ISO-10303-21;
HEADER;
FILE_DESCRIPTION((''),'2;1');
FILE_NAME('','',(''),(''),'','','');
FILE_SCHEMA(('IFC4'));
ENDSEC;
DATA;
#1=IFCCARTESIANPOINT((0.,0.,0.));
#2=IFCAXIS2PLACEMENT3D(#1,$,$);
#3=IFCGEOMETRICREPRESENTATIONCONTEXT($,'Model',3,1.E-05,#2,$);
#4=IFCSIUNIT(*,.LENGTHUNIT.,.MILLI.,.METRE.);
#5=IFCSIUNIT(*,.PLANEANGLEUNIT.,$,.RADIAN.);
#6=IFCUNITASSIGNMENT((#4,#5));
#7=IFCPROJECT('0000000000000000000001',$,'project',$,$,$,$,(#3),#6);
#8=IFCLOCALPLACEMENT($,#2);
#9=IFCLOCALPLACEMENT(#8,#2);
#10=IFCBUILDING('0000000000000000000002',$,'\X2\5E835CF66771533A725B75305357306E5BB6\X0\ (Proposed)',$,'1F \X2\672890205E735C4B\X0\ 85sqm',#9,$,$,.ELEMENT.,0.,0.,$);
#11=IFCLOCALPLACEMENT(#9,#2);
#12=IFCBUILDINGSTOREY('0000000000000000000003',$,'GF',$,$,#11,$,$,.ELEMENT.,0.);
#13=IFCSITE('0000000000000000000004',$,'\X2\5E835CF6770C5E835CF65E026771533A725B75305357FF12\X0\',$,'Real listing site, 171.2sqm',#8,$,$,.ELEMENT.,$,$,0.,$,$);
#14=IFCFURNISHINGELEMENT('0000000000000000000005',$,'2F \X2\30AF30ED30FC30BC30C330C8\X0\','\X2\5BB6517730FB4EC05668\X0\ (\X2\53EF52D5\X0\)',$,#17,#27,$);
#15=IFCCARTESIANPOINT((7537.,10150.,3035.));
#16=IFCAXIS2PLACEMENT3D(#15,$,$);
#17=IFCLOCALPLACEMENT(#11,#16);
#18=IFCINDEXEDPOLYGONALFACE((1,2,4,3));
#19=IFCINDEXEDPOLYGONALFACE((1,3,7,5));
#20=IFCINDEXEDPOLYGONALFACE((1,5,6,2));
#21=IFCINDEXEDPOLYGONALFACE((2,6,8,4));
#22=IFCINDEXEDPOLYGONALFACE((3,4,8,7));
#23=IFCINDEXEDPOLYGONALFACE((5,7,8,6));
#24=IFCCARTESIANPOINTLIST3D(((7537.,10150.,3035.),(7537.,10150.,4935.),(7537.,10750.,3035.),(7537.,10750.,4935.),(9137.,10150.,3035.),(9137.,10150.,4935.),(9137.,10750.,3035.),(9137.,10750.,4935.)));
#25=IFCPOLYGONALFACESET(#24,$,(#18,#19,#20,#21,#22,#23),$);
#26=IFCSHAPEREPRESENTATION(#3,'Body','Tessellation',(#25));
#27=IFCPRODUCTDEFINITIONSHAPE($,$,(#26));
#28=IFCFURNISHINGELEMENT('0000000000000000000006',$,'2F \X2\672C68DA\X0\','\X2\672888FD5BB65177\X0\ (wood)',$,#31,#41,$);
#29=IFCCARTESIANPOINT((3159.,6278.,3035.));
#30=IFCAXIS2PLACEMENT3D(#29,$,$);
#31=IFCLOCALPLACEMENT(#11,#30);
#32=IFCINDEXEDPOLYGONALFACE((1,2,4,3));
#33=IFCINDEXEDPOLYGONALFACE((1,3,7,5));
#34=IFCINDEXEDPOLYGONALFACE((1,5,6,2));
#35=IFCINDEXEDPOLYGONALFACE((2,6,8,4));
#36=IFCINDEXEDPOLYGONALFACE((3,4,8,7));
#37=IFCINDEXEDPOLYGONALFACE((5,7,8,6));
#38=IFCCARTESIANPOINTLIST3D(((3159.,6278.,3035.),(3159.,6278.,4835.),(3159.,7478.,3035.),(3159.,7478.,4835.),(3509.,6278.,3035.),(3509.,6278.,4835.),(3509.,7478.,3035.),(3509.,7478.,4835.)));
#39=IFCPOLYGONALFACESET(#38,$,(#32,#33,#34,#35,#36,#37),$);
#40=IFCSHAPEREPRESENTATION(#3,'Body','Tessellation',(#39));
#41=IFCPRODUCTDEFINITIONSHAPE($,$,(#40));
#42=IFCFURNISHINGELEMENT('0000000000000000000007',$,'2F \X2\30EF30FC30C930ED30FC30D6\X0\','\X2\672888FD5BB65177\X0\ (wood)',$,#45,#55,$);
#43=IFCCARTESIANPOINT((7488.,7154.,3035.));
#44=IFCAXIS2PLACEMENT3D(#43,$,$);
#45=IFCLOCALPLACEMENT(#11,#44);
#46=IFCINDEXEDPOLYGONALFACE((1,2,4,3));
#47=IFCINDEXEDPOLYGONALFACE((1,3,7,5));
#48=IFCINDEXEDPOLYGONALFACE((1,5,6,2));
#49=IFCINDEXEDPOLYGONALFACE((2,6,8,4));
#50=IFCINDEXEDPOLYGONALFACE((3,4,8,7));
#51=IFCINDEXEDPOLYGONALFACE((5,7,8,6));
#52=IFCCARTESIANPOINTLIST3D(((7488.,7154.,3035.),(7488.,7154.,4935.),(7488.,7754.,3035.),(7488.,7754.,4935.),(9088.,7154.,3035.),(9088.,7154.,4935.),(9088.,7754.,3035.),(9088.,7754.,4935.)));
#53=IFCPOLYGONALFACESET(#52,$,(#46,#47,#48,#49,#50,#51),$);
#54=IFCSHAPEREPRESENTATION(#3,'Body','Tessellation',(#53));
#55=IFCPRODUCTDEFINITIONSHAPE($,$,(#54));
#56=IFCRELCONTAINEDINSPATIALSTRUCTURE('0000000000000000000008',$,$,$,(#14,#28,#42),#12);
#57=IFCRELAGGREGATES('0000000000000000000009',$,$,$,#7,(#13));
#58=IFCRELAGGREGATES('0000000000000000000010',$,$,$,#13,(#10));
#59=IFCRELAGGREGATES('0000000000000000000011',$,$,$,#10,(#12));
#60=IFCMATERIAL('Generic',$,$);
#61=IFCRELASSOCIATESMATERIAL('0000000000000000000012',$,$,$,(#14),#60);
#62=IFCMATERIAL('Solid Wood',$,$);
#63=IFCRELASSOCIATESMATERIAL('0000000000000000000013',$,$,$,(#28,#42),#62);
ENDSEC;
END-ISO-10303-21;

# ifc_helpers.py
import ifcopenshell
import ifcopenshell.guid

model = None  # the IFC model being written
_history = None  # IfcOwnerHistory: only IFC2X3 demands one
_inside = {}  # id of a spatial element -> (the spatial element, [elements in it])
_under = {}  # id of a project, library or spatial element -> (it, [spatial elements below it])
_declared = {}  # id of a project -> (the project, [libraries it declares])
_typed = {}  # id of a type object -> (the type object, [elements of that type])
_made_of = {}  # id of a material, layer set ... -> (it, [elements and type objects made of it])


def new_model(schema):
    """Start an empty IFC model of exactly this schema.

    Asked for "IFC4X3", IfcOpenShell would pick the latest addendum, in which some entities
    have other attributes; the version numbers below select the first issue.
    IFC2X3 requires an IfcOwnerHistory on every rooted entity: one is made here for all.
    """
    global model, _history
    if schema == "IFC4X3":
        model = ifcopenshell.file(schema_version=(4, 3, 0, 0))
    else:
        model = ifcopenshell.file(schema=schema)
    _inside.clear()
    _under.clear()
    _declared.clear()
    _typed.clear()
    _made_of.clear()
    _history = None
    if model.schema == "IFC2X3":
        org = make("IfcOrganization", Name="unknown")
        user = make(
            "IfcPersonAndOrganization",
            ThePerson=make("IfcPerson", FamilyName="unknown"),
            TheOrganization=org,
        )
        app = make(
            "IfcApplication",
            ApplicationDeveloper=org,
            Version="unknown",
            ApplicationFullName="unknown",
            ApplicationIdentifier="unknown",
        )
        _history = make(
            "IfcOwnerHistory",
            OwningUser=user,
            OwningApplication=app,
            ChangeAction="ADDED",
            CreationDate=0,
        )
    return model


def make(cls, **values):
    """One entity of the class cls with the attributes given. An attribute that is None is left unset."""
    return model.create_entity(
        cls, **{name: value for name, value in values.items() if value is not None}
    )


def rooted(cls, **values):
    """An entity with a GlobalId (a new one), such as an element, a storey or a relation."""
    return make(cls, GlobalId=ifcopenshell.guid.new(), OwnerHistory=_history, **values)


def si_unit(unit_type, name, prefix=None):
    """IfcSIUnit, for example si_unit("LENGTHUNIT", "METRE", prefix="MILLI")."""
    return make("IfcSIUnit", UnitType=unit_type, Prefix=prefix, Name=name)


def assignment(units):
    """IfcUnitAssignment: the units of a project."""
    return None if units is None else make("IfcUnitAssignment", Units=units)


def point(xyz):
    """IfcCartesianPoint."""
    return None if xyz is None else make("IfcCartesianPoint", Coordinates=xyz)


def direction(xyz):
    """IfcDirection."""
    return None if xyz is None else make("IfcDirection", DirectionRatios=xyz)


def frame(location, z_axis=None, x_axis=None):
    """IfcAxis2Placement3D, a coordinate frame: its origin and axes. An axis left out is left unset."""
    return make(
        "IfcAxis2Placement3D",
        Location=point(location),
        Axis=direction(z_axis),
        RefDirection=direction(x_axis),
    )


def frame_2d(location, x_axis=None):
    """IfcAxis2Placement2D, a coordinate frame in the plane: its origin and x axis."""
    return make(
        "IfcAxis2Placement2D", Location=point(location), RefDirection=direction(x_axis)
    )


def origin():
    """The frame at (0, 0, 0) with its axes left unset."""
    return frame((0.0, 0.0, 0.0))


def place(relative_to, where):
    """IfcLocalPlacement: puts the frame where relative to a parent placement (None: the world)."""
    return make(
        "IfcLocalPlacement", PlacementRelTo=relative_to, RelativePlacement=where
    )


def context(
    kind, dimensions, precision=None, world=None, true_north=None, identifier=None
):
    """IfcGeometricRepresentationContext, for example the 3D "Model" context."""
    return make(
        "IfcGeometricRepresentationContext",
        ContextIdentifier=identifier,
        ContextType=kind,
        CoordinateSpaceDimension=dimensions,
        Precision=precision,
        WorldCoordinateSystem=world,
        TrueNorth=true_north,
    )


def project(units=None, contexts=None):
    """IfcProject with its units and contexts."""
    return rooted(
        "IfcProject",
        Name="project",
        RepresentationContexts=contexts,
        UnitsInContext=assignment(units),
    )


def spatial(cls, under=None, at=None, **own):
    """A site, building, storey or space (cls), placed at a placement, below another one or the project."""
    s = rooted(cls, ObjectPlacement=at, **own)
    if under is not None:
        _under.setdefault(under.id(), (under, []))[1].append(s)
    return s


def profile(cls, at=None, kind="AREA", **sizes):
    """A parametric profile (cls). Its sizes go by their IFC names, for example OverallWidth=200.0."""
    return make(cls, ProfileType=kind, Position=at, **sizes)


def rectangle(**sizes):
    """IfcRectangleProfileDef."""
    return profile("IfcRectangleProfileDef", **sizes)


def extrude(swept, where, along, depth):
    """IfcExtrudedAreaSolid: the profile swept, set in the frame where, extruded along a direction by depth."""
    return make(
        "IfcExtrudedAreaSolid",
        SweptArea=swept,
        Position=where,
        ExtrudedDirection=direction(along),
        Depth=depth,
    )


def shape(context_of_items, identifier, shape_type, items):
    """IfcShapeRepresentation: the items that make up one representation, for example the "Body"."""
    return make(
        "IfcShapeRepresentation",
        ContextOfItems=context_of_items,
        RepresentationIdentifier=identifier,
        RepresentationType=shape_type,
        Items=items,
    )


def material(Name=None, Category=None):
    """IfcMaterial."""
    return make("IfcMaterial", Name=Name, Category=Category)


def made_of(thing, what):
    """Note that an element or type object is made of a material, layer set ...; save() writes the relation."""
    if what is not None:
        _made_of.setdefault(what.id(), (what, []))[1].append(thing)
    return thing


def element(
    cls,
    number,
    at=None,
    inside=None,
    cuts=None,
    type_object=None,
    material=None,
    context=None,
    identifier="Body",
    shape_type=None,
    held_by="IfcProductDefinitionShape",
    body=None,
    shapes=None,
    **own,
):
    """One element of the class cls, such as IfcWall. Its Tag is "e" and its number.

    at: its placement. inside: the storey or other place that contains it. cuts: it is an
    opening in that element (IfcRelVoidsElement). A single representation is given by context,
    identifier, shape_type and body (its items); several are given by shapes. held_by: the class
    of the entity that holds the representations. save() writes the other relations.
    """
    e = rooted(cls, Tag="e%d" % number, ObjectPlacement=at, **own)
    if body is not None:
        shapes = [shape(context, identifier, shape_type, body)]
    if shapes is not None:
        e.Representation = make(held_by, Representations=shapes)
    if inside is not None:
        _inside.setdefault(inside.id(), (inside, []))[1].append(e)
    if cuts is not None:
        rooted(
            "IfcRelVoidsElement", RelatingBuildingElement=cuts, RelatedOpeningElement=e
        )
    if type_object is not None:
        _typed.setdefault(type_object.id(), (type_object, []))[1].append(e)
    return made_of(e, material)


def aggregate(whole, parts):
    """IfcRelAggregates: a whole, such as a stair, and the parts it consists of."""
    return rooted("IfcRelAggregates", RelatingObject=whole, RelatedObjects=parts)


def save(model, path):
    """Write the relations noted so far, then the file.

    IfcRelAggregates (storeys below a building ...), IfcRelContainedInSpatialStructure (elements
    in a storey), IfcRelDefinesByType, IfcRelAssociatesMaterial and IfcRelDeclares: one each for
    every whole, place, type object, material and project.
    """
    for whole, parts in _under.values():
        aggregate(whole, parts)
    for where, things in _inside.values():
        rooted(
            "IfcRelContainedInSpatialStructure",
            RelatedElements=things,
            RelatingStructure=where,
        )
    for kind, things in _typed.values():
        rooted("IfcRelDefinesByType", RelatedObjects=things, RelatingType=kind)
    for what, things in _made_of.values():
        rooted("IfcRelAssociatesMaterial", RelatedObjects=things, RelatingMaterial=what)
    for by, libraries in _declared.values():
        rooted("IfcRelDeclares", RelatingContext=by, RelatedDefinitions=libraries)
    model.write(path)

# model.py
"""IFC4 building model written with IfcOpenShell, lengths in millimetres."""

from ifc_helpers import new_model, si_unit, frame, frame_2d, origin, place, context, project, spatial, rectangle, extrude, material, element, save


model = new_model("IFC4")

# Units and contexts
model_context = context("Model", 3, precision=1e-05, world=origin())
ifc_project = project(units=[si_unit("LENGTHUNIT", "METRE", prefix="MILLI"), si_unit("PLANEANGLEUNIT", "RADIAN")], contexts=[model_context])

# Site, building, storey
site_placement = place(None, origin())
site = spatial("IfcSite", under=ifc_project, at=site_placement, Name="広島県広島市東区牛田南２", ObjectType="Real listing site, 171.2sqm", CompositionType="ELEMENT", RefElevation=0.0)
building_placement = place(site_placement, origin())
building = spatial("IfcBuilding", under=site, at=building_placement, Name="広島東区牛田南の家 (Proposed)", ObjectType="1F 木造平屋 85sqm", CompositionType="ELEMENT", ElevationOfRefHeight=0.0, ElevationOfTerrain=0.0)
storey_placement = place(building_placement, origin())
storey = spatial("IfcBuildingStorey", under=building, at=storey_placement, Name="GF", CompositionType="ELEMENT", Elevation=0.0)

# Shared definitions
ifc_material_1 = material(Name="Solid Wood")

# Shared definitions
ifc_material_2 = material(Name="Generic")

# Furnishing elements
furnishing_1_placement = place(storey_placement, frame((7537.0, 10150.0, 3035.0)))
element("IfcFurnishingElement", 1, at=furnishing_1_placement, inside=storey, material=ifc_material_2, Name="2F クローゼット", Description="家具・什器 (可動)", context=model_context, shape_type="SweptSolid", body=[
    extrude(rectangle(XDim=1600.0, YDim=600.0, at=frame_2d((800.0, 300.0))), frame((7537.0, 10150.0, 3035.0)), (0.0, 0.0, 1.0), 1900.0),
])
furnishing_2_placement = place(storey_placement, frame((3159.0, 6278.0, 3035.0)))
element("IfcFurnishingElement", 2, at=furnishing_2_placement, inside=storey, material=ifc_material_1, Name="2F 本棚", Description="木製家具 (wood)", context=model_context, shape_type="SweptSolid", body=[
    extrude(rectangle(XDim=350.0, YDim=1200.0, at=frame_2d((175.0, 600.0))), frame((3159.0, 6278.0, 3035.0)), (0.0, 0.0, 1.0), 1800.0),
])
furnishing_3_placement = place(storey_placement, frame((7488.0, 7154.0, 3035.0)))
element("IfcFurnishingElement", 3, at=furnishing_3_placement, inside=storey, material=ifc_material_1, Name="2F ワードローブ", Description="木製家具 (wood)", context=model_context, shape_type="SweptSolid", body=[
    extrude(rectangle(XDim=1600.0, YDim=600.0, at=frame_2d((800.0, 300.0))), frame((7488.0, 7154.0, 3035.0)), (0.0, 0.0, 1.0), 1900.0),
])

save(model, "model.ifc")
